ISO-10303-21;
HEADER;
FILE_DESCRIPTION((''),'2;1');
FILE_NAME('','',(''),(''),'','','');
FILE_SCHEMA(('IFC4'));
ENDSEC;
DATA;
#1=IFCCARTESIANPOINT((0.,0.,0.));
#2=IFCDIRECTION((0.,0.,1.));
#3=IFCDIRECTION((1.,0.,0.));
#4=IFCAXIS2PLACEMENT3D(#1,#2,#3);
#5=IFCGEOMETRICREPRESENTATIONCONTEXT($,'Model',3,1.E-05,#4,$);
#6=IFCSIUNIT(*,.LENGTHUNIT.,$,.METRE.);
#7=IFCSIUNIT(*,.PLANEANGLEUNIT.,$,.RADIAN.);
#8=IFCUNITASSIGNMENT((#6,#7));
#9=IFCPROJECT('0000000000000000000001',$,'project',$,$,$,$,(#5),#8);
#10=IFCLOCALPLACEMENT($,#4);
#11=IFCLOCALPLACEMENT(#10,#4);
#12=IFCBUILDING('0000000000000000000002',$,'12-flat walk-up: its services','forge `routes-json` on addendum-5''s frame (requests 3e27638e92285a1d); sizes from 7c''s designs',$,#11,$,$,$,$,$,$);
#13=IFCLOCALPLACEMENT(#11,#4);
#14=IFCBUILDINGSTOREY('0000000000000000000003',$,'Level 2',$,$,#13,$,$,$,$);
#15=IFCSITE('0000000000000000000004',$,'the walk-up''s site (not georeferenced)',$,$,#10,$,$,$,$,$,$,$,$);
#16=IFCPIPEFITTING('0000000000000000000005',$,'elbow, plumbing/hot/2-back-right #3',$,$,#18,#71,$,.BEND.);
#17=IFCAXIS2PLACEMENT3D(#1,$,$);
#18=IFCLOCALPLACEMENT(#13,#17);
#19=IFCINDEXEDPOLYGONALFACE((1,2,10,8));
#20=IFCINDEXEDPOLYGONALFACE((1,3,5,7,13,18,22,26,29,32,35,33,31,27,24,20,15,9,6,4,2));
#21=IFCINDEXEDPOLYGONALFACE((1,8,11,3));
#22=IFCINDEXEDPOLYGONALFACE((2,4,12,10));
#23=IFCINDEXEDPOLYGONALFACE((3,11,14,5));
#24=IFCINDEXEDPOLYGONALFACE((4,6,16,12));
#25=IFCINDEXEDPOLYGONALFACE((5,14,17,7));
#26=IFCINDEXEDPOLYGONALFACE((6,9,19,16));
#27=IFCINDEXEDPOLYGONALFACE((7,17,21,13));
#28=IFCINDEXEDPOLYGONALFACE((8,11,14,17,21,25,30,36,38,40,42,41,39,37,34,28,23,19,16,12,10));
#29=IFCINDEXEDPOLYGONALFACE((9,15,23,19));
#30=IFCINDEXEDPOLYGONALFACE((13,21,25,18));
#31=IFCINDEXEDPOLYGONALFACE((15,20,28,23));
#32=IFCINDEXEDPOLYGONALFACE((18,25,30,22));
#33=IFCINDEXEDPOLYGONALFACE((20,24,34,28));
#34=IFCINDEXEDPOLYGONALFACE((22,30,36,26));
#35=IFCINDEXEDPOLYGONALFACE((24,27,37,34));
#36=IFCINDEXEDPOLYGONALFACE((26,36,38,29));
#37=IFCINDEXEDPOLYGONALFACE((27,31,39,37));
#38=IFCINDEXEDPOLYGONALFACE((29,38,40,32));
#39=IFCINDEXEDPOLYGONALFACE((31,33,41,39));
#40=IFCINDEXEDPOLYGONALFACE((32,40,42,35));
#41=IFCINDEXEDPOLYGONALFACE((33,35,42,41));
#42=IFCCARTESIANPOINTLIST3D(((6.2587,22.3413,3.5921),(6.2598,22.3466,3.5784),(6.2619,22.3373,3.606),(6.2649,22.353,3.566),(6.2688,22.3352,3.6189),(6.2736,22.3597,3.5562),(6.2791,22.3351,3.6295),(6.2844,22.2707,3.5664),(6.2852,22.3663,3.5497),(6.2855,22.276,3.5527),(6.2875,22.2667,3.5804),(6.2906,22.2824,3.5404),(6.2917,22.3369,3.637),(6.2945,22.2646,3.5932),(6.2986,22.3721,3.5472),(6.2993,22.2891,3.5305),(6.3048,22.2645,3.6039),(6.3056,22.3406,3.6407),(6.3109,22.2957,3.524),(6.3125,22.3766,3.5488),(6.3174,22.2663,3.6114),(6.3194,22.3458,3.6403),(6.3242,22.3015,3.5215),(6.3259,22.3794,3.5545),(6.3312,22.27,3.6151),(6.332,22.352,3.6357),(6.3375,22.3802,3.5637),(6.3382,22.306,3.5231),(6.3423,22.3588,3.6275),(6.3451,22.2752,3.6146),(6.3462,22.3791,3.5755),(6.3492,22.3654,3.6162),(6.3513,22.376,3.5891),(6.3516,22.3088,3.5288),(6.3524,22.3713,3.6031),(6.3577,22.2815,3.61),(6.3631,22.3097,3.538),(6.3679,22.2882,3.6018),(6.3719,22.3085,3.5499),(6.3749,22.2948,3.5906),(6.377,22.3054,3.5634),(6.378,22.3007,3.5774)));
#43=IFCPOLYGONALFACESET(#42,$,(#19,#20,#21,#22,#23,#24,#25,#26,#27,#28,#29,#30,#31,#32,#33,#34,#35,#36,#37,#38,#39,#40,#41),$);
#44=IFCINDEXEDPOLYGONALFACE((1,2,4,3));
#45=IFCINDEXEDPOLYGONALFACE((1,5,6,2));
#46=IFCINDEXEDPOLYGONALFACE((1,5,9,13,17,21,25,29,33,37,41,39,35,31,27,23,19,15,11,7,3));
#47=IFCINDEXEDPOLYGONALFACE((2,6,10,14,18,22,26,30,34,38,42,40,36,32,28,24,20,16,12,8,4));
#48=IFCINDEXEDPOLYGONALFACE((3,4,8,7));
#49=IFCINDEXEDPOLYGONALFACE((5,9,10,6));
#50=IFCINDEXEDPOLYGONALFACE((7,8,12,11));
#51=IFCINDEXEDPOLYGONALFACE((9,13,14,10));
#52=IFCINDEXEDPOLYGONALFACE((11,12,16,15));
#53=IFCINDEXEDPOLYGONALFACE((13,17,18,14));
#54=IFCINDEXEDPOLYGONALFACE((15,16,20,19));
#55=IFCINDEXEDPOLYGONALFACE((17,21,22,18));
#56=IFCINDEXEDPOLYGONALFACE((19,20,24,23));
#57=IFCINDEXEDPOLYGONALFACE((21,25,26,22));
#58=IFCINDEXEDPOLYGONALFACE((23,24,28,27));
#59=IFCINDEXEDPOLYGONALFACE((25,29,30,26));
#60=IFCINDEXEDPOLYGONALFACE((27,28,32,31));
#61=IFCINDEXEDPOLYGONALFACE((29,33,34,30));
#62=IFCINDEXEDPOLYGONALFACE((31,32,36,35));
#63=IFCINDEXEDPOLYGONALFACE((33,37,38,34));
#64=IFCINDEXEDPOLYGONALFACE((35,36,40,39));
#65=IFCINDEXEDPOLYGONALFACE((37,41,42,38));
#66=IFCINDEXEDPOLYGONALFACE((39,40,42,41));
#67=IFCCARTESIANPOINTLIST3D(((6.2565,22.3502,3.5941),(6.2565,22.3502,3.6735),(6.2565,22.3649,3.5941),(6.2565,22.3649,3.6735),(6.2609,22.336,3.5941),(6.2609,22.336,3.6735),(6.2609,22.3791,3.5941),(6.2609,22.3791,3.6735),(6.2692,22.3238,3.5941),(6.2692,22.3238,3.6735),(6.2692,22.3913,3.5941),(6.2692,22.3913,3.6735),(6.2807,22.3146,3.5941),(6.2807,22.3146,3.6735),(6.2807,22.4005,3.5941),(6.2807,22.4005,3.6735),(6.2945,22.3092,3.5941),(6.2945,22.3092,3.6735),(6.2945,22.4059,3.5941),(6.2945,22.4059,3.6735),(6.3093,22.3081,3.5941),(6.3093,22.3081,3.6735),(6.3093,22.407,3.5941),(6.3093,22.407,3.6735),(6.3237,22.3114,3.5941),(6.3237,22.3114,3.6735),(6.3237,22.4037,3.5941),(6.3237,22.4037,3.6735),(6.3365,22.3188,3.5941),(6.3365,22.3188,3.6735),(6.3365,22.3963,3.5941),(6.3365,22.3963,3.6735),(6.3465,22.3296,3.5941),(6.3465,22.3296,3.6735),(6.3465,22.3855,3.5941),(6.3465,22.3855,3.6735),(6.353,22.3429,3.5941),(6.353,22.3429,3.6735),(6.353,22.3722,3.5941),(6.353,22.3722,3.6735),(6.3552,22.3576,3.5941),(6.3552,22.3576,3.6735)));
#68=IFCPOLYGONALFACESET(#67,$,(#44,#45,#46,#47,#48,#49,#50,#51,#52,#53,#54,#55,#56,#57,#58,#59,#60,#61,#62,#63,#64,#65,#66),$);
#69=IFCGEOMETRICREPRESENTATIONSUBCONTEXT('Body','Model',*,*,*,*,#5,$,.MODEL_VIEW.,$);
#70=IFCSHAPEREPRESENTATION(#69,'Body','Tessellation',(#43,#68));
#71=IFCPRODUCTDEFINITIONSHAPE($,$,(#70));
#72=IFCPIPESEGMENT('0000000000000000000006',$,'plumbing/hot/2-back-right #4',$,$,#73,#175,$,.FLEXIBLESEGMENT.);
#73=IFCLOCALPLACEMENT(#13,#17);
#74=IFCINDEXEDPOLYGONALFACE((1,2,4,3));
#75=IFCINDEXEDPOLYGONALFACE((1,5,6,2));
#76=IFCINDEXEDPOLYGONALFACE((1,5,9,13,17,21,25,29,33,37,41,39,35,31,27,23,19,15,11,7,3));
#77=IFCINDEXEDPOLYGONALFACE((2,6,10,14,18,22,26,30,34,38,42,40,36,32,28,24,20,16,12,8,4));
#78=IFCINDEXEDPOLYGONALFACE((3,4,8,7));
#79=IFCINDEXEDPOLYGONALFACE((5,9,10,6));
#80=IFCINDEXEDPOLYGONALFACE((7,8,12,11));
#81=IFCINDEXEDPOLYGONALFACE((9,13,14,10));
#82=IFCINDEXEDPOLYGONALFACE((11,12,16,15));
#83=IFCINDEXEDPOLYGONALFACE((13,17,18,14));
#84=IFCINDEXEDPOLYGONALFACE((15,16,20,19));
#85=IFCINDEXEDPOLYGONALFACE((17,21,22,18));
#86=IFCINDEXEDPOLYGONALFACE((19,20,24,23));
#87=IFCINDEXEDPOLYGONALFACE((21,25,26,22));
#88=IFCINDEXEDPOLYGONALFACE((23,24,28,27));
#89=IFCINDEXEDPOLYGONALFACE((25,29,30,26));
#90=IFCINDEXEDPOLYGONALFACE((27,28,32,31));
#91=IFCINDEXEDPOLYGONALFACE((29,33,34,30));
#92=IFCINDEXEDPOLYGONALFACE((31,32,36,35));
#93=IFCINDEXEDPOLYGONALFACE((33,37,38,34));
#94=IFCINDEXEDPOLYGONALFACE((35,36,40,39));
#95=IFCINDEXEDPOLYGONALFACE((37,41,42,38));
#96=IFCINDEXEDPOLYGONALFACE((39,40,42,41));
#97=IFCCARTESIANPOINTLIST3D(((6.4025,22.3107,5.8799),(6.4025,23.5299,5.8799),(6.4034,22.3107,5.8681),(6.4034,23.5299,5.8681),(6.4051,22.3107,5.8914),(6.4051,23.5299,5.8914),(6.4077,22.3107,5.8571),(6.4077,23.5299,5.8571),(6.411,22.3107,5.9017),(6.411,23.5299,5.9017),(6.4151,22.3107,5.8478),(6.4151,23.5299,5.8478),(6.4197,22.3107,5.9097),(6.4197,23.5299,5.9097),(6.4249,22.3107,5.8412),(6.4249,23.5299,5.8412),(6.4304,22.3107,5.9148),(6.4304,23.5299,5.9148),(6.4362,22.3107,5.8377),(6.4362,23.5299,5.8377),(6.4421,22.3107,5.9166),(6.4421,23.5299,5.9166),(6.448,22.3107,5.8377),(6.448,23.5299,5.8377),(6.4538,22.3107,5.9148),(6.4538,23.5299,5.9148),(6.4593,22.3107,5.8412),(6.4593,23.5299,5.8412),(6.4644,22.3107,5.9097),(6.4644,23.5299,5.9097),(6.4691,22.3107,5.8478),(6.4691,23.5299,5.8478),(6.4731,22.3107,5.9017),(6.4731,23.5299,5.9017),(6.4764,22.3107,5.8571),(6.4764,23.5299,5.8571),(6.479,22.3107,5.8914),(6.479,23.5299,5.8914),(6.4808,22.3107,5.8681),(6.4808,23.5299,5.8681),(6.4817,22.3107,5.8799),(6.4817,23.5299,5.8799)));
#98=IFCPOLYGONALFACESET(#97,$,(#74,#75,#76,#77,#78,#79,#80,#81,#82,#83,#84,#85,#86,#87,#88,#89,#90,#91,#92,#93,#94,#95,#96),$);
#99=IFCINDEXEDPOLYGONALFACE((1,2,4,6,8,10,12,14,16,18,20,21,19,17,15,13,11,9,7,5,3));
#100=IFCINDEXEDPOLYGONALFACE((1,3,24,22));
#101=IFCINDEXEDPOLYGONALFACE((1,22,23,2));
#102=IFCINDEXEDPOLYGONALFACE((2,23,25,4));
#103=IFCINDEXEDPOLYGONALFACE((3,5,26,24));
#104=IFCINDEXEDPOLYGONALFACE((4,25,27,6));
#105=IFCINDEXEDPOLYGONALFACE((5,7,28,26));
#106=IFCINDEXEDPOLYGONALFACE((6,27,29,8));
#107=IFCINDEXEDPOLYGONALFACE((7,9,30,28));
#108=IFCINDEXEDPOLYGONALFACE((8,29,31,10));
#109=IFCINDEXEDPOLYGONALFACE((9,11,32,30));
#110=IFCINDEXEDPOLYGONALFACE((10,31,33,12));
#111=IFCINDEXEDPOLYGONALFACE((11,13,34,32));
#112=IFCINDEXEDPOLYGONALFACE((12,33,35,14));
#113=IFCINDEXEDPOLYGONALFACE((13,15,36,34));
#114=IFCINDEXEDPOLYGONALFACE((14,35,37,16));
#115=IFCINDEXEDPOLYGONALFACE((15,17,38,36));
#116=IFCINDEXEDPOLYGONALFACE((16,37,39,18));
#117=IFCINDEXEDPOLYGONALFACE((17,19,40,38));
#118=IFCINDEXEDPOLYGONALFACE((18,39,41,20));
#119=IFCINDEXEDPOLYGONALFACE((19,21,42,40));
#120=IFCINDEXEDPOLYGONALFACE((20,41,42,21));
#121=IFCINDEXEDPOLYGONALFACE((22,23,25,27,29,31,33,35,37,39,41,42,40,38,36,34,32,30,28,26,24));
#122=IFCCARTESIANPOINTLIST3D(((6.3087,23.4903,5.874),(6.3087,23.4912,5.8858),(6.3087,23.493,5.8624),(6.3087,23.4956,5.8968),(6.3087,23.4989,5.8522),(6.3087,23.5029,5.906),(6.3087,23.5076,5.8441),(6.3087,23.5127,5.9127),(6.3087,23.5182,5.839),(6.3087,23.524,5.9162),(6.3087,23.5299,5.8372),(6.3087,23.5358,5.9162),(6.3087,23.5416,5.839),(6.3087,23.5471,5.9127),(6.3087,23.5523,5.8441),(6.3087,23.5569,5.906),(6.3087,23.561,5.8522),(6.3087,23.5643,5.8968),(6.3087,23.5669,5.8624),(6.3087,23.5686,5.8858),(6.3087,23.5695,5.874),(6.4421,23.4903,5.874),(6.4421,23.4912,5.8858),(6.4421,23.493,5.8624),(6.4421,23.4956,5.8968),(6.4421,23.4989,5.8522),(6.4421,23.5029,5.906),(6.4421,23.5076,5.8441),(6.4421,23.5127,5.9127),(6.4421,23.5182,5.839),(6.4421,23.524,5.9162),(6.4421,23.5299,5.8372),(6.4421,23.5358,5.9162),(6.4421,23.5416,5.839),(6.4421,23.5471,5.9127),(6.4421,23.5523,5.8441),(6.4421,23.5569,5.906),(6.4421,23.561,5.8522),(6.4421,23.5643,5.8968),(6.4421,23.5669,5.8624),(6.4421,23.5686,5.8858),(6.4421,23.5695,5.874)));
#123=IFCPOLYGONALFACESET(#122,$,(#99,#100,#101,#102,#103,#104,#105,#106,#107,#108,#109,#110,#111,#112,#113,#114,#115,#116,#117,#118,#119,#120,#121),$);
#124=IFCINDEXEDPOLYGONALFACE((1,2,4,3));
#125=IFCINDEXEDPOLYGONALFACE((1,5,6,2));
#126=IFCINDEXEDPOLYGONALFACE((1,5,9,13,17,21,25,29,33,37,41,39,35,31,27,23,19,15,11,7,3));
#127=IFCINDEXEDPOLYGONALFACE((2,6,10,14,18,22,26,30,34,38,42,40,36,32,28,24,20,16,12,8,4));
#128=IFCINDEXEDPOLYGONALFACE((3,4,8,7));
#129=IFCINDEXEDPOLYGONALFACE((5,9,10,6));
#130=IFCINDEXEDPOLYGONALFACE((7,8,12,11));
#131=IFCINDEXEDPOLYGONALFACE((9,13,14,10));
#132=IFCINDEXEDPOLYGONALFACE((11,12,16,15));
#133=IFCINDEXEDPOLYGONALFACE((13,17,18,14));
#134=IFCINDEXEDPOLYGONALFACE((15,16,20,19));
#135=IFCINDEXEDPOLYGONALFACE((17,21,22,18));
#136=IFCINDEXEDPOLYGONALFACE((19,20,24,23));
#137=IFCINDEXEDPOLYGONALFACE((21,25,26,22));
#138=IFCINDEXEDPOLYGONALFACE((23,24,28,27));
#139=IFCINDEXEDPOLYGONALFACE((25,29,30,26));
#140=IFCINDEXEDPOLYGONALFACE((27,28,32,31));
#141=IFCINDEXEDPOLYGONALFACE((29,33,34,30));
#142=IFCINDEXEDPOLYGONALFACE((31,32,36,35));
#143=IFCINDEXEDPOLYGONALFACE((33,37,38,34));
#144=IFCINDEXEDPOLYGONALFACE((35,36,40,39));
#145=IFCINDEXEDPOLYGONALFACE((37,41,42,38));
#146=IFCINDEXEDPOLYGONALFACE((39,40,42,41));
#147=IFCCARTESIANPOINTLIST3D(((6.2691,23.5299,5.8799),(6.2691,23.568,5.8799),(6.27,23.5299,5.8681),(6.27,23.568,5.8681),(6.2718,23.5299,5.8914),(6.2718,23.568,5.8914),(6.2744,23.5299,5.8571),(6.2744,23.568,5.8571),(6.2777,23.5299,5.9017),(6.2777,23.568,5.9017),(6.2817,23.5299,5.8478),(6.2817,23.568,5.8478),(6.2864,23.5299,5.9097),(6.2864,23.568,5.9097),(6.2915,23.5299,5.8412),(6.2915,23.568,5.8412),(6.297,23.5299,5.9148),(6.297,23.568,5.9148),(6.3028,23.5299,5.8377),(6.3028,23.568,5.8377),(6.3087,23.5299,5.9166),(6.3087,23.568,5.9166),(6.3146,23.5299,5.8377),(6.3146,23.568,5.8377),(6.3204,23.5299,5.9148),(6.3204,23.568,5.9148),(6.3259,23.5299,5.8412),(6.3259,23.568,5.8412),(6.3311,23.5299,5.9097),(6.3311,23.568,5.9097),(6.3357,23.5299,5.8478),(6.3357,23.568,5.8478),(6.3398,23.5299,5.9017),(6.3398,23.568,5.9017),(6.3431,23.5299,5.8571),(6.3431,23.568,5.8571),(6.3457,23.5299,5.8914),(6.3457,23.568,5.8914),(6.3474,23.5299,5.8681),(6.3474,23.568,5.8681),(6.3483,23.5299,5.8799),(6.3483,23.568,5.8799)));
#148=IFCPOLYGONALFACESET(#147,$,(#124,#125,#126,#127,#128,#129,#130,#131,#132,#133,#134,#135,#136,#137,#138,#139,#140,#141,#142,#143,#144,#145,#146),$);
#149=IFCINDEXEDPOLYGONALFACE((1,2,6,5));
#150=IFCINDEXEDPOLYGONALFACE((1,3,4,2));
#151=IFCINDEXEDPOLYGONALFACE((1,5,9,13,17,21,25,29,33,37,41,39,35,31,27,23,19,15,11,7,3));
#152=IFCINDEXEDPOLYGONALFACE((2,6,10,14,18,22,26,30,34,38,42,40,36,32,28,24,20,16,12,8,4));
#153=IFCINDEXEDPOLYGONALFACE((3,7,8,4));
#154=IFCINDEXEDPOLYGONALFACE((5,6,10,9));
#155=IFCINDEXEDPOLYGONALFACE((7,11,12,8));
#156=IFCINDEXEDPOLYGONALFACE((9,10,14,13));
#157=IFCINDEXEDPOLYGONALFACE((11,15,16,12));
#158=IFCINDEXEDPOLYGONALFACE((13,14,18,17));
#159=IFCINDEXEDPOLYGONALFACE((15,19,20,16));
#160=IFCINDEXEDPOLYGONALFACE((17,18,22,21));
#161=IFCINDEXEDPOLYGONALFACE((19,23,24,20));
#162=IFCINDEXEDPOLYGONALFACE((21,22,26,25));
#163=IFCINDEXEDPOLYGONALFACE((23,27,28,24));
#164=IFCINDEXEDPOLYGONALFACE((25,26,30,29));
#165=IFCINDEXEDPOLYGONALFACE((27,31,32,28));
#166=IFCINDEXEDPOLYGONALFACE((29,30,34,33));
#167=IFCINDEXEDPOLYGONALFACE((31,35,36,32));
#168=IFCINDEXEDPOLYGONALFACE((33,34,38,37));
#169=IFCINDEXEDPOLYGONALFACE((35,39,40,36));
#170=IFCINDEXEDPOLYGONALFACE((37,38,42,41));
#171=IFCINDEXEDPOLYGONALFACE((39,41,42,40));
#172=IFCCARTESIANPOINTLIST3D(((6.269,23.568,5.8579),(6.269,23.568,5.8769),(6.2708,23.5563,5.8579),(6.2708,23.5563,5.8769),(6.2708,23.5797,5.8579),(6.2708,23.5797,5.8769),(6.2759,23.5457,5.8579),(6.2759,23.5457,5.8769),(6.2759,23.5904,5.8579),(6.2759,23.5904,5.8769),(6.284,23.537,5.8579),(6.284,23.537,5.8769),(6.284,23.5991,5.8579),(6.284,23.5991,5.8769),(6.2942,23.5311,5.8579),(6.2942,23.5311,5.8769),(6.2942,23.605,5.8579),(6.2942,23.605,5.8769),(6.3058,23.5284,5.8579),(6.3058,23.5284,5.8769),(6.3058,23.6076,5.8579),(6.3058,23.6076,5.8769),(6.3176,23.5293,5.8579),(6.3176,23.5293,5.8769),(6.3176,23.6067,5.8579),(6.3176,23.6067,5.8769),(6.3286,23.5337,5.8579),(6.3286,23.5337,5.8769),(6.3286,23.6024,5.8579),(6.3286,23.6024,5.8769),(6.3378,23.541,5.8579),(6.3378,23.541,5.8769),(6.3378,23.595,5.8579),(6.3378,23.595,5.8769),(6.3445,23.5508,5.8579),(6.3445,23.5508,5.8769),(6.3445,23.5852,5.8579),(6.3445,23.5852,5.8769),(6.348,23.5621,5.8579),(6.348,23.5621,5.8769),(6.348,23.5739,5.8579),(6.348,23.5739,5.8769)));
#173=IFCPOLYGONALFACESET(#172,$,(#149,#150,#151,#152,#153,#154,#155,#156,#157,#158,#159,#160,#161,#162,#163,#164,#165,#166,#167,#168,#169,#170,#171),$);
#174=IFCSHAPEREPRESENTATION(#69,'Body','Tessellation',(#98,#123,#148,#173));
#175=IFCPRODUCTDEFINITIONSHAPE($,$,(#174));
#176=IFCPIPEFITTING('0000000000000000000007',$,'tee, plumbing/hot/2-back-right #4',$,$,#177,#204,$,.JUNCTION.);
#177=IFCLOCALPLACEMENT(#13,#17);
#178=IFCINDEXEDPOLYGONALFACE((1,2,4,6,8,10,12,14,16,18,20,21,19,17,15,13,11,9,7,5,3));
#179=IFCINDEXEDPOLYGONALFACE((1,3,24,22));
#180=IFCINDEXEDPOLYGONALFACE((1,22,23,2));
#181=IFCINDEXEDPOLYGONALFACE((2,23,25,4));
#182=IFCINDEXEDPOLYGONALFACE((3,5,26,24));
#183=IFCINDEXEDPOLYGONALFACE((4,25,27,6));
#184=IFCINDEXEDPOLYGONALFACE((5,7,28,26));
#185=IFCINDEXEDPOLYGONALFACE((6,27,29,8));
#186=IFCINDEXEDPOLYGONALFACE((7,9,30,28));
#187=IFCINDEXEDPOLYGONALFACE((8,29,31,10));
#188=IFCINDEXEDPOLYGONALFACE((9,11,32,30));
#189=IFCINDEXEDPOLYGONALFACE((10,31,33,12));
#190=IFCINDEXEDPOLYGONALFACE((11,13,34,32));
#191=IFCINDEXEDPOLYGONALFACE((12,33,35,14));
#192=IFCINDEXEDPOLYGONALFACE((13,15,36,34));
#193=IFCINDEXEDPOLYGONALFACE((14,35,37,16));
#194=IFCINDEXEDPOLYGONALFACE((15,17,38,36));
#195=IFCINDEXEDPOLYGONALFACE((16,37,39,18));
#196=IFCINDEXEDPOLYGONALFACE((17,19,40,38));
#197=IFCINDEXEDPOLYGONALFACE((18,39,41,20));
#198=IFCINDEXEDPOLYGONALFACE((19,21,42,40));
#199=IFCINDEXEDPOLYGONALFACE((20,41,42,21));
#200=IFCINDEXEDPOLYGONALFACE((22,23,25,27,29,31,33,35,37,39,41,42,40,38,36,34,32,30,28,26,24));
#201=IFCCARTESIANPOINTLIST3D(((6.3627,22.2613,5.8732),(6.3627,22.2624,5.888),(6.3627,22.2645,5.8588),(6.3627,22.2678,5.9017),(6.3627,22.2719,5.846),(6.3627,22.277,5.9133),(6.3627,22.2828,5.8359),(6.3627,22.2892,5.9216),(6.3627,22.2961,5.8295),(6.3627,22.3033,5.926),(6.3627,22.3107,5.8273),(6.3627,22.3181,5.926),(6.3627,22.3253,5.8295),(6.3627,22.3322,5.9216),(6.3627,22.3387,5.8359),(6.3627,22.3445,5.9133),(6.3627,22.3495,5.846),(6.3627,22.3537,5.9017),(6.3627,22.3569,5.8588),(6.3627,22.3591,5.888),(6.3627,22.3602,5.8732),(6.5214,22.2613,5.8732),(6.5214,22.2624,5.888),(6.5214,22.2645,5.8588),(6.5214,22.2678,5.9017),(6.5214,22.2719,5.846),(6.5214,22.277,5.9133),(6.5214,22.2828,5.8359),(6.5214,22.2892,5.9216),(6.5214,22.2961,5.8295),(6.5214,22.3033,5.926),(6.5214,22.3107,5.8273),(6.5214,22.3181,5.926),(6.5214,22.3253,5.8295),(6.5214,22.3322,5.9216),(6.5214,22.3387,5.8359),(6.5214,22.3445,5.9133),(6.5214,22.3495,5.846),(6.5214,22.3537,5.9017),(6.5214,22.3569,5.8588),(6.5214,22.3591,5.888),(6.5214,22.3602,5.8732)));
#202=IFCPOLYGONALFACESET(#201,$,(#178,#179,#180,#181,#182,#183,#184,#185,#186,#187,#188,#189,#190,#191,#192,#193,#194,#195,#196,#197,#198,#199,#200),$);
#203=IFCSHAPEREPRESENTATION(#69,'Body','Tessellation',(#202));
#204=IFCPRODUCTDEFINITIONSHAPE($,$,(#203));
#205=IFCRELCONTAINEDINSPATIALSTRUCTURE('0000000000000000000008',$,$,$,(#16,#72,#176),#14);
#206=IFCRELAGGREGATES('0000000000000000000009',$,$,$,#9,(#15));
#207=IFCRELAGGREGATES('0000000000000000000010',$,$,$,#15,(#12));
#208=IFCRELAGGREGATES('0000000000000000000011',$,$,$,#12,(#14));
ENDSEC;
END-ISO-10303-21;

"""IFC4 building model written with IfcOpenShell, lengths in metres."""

from ifc_helpers import new_model, entity, si_unit, frame, origin_with_axes, place, context, subcontext, project, spatial, element, save


model = new_model("IFC4")

# Units and contexts
model_context = context("Model", 3, precision=1e-05, world=origin_with_axes())
body_context = subcontext(model_context, "Body", "Model", "MODEL_VIEW")
ifc_project = project(units=[si_unit("LENGTHUNIT", "METRE"), si_unit("PLANEANGLEUNIT", "RADIAN")], contexts=[model_context])

# Site, building, storey
site_placement = place(None, origin_with_axes())
site = spatial("IfcSite", under=ifc_project, at=site_placement, Name="the walk-up's site (not georeferenced)")
building_placement = place(site_placement, origin_with_axes())
building = spatial("IfcBuilding", under=site, at=building_placement, Name="12-flat walk-up: its services", Description="forge `routes-json` on addendum-5's frame (requests 3e27638e92285a1d); sizes from 7c's designs")
storey_placement = place(building_placement, origin_with_axes())
storey = spatial("IfcBuildingStorey", under=building, at=storey_placement, Name="Level 2")

# Pipe fitting
pipe_fitting_1_placement = place(storey_placement, frame((6.3312, 22.287, 3.5684), z_axis=(0.0, 0.0, 1.0), x_axis=(1.0, 0.0, 0.0)))
element("IfcPipeFitting", 1, at=pipe_fitting_1_placement, inside=storey, Name="elbow, plumbing/hot/2-back-right #3", PredefinedType="BEND", context=body_context, shape_type="AdvancedSweptSolid", body=[
    entity("IfcSweptDiskSolid", entity("IfcPolyline", [entity("IfcCartesianPoint", [0.0, 0.0, 0.0]), entity("IfcCartesianPoint", [-0.0257, 0.0706, 0.0257])]), 0.0496),
    entity("IfcSweptDiskSolid", entity("IfcPolyline", [entity("IfcCartesianPoint", [-0.0257, 0.0706, 0.0257]), entity("IfcCartesianPoint", [-0.0257, 0.0706, 0.105])]), 0.0496),
])

# Pipe segment
pipe_segment_1_placement = place(storey_placement, frame((6.4421, 22.3107, 5.8769), z_axis=(0.0, 0.0, 1.0), x_axis=(1.0, 0.0, 0.0)))
element("IfcPipeSegment", 2, at=pipe_segment_1_placement, inside=storey, Name="plumbing/hot/2-back-right #4", PredefinedType="FLEXIBLESEGMENT", context=body_context, shape_type="AdvancedSweptSolid", body=[
    entity("IfcSweptDiskSolid", entity("IfcPolyline", [entity("IfcCartesianPoint", [0.0, 0.0, 0.0]), entity("IfcCartesianPoint", [0.0, 1.2192, 0.0])]), 0.0397),
    entity("IfcSweptDiskSolid", entity("IfcPolyline", [entity("IfcCartesianPoint", [0.0, 1.2192, 0.0]), entity("IfcCartesianPoint", [-0.1334, 1.2192, 0.0])]), 0.0397),
    entity("IfcSweptDiskSolid", entity("IfcPolyline", [entity("IfcCartesianPoint", [-0.1334, 1.2192, 0.0]), entity("IfcCartesianPoint", [-0.1334, 1.2573, 0.0])]), 0.0397),
    entity("IfcSweptDiskSolid", entity("IfcPolyline", [entity("IfcCartesianPoint", [-0.1334, 1.2573, 0.0]), entity("IfcCartesianPoint", [-0.1334, 1.2573, -0.0191])]), 0.0397),
])

# Pipe fitting
pipe_fitting_2_placement = place(storey_placement, frame((6.5214, 22.3107, 5.8769), z_axis=(0.0, 0.0, 1.0), x_axis=(1.0, 0.0, 0.0)))
element("IfcPipeFitting", 3, at=pipe_fitting_2_placement, inside=storey, Name="tee, plumbing/hot/2-back-right #4", PredefinedType="JUNCTION", context=body_context, shape_type="AdvancedSweptSolid", body=[
    entity("IfcSweptDiskSolid", entity("IfcPolyline", [entity("IfcCartesianPoint", [0.0, 0.0, 0.0]), entity("IfcCartesianPoint", [-0.1587, 0.0, 0.0])]), 0.0496),
])

save(model, "model.ifc")
